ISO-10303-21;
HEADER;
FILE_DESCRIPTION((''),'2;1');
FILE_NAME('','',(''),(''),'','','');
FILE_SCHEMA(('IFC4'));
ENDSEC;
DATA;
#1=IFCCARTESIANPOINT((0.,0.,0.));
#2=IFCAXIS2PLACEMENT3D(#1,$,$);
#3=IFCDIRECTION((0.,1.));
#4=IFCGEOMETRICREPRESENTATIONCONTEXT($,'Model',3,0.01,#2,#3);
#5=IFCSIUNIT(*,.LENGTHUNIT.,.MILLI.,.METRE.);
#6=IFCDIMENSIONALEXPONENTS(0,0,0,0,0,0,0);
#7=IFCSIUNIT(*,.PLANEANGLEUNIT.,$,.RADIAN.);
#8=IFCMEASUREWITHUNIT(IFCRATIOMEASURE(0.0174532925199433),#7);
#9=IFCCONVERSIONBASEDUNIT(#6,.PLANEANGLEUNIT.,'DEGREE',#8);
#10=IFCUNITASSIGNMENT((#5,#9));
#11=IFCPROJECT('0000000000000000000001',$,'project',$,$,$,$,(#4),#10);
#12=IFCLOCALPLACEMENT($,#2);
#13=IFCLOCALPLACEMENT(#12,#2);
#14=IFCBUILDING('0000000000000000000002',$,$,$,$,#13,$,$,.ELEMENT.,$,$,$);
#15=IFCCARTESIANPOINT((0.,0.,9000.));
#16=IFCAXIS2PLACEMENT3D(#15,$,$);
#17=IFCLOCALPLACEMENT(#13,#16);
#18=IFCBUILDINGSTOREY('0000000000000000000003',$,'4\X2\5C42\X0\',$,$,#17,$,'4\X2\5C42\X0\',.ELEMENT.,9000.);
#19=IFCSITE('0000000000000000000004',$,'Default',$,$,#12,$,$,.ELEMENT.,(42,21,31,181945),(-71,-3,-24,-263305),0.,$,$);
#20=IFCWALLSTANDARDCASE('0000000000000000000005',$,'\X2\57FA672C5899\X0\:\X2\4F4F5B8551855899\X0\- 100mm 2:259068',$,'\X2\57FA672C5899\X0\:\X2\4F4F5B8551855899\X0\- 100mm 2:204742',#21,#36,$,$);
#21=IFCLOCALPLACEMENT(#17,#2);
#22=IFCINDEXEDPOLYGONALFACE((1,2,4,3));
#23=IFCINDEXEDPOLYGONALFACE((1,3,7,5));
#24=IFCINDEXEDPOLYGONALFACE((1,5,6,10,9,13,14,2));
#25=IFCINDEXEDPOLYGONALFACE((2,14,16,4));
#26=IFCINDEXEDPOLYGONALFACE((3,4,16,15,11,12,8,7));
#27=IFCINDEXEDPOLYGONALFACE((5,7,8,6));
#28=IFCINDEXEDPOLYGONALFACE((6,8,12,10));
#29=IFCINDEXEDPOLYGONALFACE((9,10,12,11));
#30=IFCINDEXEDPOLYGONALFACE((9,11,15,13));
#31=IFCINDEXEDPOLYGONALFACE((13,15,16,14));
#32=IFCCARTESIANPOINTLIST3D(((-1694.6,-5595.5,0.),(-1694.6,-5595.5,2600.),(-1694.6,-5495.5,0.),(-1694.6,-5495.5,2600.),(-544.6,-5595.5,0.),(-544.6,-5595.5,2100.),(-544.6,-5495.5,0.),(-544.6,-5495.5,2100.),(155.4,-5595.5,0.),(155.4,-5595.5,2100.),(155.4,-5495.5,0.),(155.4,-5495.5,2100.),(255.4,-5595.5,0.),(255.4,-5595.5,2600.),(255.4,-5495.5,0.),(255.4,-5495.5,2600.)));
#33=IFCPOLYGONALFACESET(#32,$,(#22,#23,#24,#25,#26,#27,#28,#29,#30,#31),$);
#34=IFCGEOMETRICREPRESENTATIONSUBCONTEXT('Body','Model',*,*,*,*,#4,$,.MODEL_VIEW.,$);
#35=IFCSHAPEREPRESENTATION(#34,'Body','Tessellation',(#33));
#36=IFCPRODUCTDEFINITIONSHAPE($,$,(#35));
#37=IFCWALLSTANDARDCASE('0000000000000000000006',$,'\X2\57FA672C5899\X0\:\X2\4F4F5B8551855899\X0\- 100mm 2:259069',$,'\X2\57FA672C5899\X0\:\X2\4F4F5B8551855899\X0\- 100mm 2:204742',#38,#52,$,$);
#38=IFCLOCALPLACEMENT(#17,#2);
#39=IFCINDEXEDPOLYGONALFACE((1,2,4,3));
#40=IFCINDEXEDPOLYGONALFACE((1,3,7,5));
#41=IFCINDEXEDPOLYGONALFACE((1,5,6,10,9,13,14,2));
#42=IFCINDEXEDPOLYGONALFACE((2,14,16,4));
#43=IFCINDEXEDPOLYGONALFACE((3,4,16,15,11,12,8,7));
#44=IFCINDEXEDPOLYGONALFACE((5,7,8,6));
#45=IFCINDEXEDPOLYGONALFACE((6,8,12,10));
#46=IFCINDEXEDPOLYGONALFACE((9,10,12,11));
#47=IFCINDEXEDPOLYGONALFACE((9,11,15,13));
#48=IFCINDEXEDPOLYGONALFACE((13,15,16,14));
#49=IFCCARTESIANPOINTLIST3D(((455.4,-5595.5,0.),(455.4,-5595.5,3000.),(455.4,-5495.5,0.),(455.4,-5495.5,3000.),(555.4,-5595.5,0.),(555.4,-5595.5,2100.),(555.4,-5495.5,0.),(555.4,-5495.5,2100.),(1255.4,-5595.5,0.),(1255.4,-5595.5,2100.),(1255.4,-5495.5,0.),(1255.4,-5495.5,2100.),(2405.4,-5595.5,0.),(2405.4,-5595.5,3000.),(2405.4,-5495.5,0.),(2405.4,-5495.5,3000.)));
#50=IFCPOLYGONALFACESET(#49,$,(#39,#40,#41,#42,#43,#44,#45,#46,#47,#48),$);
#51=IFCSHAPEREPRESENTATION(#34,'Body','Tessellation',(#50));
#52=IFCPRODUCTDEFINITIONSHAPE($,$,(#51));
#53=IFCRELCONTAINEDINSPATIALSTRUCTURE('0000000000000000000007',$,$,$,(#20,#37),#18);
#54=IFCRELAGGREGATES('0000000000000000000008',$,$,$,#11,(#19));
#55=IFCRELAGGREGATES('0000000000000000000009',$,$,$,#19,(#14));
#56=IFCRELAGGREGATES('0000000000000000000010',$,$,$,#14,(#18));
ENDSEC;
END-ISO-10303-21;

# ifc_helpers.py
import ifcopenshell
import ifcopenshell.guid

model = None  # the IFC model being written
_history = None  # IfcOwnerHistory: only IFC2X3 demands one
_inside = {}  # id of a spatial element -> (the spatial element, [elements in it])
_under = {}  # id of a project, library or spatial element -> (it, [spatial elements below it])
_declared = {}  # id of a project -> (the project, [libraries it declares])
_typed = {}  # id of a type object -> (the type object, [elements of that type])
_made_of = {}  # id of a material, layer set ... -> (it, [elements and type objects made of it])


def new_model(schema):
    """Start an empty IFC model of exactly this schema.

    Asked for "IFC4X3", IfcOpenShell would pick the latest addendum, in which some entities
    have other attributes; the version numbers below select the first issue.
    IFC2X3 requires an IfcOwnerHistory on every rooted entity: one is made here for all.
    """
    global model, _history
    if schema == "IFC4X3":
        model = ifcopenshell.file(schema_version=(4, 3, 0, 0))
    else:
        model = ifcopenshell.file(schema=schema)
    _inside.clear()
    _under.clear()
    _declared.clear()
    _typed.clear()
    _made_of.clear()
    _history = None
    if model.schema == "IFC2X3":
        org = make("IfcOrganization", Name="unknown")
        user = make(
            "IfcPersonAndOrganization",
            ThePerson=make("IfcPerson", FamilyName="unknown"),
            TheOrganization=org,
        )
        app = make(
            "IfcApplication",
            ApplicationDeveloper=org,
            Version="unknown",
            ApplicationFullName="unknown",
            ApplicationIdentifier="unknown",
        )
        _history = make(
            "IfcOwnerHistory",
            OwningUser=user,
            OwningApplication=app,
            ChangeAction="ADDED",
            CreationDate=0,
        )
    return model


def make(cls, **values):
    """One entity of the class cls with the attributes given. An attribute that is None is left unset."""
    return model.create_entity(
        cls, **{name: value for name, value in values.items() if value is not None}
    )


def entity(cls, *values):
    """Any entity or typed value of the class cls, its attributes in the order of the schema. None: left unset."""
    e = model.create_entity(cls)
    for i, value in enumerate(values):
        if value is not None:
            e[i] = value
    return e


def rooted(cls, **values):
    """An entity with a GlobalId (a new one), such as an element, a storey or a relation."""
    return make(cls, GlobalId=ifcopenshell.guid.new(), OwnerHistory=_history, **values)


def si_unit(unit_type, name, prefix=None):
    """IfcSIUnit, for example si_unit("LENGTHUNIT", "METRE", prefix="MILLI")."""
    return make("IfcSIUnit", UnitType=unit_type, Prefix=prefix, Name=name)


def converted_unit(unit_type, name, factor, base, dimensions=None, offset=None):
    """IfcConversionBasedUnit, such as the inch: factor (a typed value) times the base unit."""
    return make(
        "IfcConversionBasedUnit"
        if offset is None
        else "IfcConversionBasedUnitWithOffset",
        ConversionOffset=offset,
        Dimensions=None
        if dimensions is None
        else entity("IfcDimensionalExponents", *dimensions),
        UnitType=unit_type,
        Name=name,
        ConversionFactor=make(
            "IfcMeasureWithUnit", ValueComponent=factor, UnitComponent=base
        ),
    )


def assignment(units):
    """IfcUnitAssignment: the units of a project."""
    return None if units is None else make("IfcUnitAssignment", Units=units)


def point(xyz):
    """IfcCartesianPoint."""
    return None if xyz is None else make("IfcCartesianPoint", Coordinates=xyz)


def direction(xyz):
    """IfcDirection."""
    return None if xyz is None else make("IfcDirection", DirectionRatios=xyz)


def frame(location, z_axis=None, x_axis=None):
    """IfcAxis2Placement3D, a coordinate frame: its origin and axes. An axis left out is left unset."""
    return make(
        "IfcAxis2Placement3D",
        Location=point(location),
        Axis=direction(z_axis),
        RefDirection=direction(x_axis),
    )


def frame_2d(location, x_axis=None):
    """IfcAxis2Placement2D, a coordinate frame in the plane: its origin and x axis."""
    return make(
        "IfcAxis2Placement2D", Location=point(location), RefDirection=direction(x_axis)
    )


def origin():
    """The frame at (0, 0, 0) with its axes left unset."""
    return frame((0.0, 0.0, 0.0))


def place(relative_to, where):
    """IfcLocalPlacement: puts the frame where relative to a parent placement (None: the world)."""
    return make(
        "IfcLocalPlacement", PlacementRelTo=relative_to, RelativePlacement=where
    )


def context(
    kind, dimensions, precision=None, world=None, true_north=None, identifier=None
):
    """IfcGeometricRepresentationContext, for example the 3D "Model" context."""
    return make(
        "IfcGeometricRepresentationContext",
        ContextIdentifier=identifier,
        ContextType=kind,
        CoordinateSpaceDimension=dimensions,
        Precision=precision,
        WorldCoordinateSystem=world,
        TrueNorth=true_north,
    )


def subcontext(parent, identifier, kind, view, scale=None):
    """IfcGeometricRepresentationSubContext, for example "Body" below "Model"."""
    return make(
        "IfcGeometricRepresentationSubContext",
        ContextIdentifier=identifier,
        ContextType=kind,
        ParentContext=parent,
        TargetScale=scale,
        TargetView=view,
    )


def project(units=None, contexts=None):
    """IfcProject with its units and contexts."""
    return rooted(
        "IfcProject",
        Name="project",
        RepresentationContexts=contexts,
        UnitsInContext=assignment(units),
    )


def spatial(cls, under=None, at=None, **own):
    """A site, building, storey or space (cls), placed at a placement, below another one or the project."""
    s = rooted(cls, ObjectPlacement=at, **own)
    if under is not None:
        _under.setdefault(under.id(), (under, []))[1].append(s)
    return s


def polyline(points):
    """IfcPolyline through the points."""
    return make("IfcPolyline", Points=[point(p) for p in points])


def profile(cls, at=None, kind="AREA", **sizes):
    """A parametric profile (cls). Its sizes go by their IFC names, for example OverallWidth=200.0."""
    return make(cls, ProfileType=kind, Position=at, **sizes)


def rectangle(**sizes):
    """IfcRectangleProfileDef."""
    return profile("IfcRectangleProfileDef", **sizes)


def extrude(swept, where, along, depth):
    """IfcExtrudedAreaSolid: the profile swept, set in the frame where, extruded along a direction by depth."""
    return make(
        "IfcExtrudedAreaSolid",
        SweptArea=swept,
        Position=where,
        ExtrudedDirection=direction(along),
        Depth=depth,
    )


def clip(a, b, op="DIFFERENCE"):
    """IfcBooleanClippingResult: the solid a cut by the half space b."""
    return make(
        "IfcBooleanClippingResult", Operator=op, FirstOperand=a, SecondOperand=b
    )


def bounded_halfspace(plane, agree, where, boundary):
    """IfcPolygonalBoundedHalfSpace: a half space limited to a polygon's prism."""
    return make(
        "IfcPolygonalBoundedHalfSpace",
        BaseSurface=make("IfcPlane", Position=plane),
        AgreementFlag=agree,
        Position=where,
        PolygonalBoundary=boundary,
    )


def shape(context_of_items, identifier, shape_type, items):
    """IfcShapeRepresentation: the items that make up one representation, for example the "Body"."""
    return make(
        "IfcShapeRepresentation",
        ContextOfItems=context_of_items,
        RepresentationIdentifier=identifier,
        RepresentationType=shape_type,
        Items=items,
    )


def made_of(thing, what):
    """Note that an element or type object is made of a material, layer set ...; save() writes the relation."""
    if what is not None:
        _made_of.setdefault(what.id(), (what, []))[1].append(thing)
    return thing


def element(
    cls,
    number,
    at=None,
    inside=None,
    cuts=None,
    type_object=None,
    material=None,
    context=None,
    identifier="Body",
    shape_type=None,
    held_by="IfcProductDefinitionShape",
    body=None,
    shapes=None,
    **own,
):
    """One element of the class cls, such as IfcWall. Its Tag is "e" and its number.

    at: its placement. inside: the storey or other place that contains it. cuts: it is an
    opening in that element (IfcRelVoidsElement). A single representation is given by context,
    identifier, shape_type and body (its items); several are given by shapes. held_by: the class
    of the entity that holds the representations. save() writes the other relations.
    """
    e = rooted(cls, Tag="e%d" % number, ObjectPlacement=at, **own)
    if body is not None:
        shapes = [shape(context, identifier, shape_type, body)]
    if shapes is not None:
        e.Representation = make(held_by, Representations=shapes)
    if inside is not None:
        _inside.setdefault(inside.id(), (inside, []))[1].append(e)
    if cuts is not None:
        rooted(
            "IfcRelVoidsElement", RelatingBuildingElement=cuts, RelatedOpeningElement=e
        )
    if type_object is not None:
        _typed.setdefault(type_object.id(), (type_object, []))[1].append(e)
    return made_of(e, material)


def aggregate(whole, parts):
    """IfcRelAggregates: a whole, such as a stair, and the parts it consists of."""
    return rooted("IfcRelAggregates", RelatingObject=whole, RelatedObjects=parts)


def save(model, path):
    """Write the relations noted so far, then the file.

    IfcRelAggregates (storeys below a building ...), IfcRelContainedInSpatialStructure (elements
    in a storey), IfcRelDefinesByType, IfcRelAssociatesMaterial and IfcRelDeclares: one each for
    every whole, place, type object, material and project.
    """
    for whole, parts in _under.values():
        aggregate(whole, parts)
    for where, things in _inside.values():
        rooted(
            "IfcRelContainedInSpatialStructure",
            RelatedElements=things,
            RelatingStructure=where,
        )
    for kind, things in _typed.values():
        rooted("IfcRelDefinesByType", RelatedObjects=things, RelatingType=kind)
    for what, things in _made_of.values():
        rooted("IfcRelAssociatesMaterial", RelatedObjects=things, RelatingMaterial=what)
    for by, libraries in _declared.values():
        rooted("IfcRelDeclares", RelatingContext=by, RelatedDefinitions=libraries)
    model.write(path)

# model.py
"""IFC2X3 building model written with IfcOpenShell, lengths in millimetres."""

from ifc_helpers import new_model, entity, si_unit, converted_unit, direction, frame, frame_2d, origin, place, context, subcontext, project, spatial, polyline, rectangle, extrude, clip, bounded_halfspace, element, save


model = new_model("IFC2X3")

# Units and contexts
model_context = context("Model", 3, precision=0.01, world=origin(), true_north=direction((0.0, 1.0)))
body_context = subcontext(model_context, "Body", "Model", "MODEL_VIEW")
ifc_project = project(units=[si_unit("LENGTHUNIT", "METRE", prefix="MILLI"), converted_unit("PLANEANGLEUNIT", "DEGREE", entity("IfcRatioMeasure", 0.0174532925199433), si_unit("PLANEANGLEUNIT", "RADIAN"), dimensions=[0, 0, 0, 0, 0, 0, 0])], contexts=[model_context])

# Site, building, storey
site_placement = place(None, origin())
site = spatial("IfcSite", under=ifc_project, at=site_placement, Name="Default", CompositionType="ELEMENT", RefLatitude=(42, 21, 31, 181945), RefLongitude=(-71, -3, -24, -263305), RefElevation=0.0)
building_placement = place(site_placement, origin())
building = spatial("IfcBuilding", under=site, at=building_placement, CompositionType="ELEMENT")
storey_placement = place(building_placement, frame((0.0, 0.0, 9000.0)))
storey = spatial("IfcBuildingStorey", under=building, at=storey_placement, Name="4层", LongName="4层", CompositionType="ELEMENT", Elevation=9000.0)

# Walls, openings
wall_1_placement = place(storey_placement, frame((-1694.6, -5545.5, 0.0)))
wall_1 = element("IfcWallStandardCase", 1, at=wall_1_placement, inside=storey, Name="基本墙:住宅内墙- 100mm 2:259068", ObjectType="基本墙:住宅内墙- 100mm 2:204742", context=body_context, shape_type="Clipping", body=[
    clip(extrude(rectangle(XDim=1950.0, YDim=100.0, at=frame_2d((975.0, 0.0), x_axis=(-1.0, 0.0))), origin(), (0.0, 0.0, 1.0), 2600.0), bounded_halfspace(frame((0.0, -50.0, 2600.0), z_axis=(0.0, 0.0, -1.0), x_axis=(-1.0, 0.0, 0.0)), True, frame((0.0, -50.0, 2600.0), z_axis=(0.0, 0.0, -1.0), x_axis=(-1.0, 0.0, 0.0)), polyline([(0.0, 0.0), (0.0, 100.0), (-1950.0, 100.0), (-1950.0, 0.0), (0.0, 0.0)]))),
])
opening_1_placement = place(wall_1_placement, frame((1150.0, -50.0, 0.0)))
element("IfcOpeningElement", 2, at=opening_1_placement, cuts=wall_1, ObjectType="Opening", context=body_context, shape_type="SweptSolid", body=[
    extrude(rectangle(XDim=2100.0, YDim=700.0, at=frame_2d((1050.0, 350.0), x_axis=(1.0, 0.0))), frame((0.0, 0.0, 0.0), z_axis=(0.0, 1.0, 0.0), x_axis=(0.0, 0.0, 1.0)), (0.0, 0.0, 1.0), 100.0),
])
wall_2_placement = place(storey_placement, frame((2405.4, -5545.5, 0.0), z_axis=(0.0, 0.0, 1.0), x_axis=(-1.0, 0.0, 0.0)))
wall_2 = element("IfcWallStandardCase", 3, at=wall_2_placement, inside=storey, Name="基本墙:住宅内墙- 100mm 2:259069", ObjectType="基本墙:住宅内墙- 100mm 2:204742", context=body_context, shape_type="SweptSolid", body=[
    extrude(rectangle(XDim=1950.0, YDim=100.0, at=frame_2d((975.0, 0.0), x_axis=(-1.0, 0.0))), origin(), (0.0, 0.0, 1.0), 3000.0),
])
opening_2_placement = place(wall_2_placement, frame((1850.0, 50.0, 0.0)))
element("IfcOpeningElement", 4, at=opening_2_placement, cuts=wall_2, ObjectType="Opening", context=body_context, shape_type="SweptSolid", body=[
    extrude(rectangle(XDim=2100.0, YDim=700.0, at=frame_2d((1050.0, 350.0), x_axis=(1.0, 0.0))), frame((0.0, 0.0, 0.0), z_axis=(0.0, -1.0, 0.0), x_axis=(0.0, 0.0, 1.0)), (0.0, 0.0, 1.0), 100.0),
])

save(model, "model.ifc")
